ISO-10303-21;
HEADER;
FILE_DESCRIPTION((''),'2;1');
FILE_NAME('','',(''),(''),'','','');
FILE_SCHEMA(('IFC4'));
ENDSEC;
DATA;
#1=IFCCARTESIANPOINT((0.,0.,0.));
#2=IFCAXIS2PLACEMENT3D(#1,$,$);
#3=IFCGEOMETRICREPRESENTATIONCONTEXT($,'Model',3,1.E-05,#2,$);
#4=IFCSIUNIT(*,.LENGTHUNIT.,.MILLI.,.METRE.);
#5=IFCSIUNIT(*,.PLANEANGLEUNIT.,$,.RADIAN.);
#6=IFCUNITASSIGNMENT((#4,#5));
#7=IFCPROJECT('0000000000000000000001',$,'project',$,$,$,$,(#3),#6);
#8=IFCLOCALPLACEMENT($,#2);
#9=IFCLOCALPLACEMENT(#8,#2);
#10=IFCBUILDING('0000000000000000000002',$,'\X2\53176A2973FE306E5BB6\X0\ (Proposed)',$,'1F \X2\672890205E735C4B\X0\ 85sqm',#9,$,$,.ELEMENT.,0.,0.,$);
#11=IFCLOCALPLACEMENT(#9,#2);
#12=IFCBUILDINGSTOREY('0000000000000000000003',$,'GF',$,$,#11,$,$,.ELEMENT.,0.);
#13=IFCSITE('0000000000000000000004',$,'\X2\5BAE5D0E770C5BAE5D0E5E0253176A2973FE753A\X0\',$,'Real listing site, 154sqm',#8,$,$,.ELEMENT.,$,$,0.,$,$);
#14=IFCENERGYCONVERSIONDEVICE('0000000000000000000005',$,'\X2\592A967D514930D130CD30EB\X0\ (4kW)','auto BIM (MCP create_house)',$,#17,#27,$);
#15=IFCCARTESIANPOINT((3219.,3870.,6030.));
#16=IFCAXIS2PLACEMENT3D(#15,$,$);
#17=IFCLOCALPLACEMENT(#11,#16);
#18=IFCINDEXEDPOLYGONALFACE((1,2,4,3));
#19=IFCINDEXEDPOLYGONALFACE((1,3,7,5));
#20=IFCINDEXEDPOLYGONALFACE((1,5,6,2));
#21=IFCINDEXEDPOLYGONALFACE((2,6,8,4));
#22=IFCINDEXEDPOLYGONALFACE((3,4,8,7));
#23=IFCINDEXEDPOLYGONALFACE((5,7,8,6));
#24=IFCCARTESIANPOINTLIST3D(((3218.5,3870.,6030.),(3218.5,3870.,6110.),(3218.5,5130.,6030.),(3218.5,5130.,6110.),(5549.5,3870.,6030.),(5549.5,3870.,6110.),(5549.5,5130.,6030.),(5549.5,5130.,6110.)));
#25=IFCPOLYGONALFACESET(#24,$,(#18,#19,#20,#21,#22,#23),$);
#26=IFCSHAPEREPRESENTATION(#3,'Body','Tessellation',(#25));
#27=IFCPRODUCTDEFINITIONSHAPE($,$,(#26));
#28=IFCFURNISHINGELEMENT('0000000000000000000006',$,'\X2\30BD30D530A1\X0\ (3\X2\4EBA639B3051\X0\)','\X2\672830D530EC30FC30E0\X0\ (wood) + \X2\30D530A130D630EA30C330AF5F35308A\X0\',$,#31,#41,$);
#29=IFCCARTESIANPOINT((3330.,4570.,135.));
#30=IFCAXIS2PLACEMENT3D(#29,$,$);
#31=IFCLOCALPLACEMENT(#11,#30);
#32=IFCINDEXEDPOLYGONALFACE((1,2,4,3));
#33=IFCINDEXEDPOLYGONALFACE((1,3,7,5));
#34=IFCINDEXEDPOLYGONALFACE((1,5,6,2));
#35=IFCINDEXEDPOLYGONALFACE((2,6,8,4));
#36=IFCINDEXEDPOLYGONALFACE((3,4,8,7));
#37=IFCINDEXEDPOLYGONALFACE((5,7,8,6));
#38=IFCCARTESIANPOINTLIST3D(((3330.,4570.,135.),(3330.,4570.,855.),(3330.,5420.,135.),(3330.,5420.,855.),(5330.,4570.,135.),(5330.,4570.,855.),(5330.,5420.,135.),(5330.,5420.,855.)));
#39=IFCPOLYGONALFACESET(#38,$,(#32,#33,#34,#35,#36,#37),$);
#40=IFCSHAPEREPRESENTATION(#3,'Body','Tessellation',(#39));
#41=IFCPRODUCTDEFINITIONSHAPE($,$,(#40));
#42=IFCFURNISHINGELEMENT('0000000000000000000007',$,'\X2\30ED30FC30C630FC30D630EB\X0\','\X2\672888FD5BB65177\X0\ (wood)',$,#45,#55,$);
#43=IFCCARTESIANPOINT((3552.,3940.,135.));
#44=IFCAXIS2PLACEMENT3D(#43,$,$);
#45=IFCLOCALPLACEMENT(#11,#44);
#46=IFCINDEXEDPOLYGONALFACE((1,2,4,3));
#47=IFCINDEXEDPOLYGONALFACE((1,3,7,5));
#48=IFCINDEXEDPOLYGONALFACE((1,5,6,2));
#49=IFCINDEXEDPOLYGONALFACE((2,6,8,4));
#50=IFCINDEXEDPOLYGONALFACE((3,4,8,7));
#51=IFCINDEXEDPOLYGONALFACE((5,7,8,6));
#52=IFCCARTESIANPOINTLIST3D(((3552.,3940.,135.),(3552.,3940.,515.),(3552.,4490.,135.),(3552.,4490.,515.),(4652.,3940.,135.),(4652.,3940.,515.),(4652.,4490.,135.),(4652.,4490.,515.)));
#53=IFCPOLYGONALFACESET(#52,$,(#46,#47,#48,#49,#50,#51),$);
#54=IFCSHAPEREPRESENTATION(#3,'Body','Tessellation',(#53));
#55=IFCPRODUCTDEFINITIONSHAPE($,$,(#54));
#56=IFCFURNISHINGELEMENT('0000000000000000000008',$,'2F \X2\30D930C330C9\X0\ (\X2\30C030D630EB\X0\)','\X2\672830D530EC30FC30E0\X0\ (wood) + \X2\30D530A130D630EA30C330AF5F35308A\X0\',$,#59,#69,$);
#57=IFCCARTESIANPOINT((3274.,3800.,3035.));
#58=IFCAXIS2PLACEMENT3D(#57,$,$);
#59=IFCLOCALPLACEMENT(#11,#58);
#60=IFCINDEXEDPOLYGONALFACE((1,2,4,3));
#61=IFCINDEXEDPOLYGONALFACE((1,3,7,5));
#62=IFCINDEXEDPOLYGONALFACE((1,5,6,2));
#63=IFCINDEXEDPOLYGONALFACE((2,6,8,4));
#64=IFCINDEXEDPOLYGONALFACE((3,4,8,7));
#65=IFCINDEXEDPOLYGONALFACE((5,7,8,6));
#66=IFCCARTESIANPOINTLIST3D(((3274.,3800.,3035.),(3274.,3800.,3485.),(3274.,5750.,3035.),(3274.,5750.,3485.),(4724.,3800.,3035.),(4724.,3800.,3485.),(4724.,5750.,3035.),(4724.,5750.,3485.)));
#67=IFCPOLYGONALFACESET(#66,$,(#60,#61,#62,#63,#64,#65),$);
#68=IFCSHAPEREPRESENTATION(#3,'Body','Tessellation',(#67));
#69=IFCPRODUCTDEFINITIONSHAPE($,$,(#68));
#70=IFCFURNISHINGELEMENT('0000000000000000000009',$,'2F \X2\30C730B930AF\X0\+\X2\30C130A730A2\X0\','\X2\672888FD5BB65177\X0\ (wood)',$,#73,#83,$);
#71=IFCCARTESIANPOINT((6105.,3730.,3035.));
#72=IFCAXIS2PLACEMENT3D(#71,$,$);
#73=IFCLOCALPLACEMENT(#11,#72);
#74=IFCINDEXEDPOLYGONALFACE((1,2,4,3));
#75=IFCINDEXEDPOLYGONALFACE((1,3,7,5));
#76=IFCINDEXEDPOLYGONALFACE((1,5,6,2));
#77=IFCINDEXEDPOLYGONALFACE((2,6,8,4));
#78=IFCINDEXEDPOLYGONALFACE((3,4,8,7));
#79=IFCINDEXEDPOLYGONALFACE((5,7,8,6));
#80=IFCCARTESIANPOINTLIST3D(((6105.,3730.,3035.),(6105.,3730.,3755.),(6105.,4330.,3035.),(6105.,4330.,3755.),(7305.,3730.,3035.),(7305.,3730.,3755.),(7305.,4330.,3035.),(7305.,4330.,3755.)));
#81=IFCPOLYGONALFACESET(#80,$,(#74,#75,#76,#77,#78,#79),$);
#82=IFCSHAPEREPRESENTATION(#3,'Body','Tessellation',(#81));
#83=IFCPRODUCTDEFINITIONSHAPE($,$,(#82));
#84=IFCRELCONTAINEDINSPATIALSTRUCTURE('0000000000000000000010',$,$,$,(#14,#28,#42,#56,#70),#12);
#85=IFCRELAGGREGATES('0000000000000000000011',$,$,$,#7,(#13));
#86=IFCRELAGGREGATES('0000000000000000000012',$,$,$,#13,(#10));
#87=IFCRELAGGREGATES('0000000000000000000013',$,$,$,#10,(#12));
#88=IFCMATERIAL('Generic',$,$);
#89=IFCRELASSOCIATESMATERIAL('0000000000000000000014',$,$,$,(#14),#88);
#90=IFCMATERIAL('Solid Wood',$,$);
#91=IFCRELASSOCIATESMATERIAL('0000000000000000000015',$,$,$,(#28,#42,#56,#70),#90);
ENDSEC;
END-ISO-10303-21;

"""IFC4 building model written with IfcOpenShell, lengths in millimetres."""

from ifc_helpers import new_model, si_unit, frame, frame_2d, origin, place, context, project, spatial, rectangle, extrude, material, element, save


model = new_model("IFC4")

# Units and contexts
model_context = context("Model", 3, precision=1e-05, world=origin())
ifc_project = project(units=[si_unit("LENGTHUNIT", "METRE", prefix="MILLI"), si_unit("PLANEANGLEUNIT", "RADIAN")], contexts=[model_context])

# Site, building, storey
site_placement = place(None, origin())
site = spatial("IfcSite", under=ifc_project, at=site_placement, Name="宮崎県宮崎市北権現町", ObjectType="Real listing site, 154sqm", CompositionType="ELEMENT", RefElevation=0.0)
building_placement = place(site_placement, origin())
building = spatial("IfcBuilding", under=site, at=building_placement, Name="北権現の家 (Proposed)", ObjectType="1F 木造平屋 85sqm", CompositionType="ELEMENT", ElevationOfRefHeight=0.0, ElevationOfTerrain=0.0)
storey_placement = place(building_placement, origin())
storey = spatial("IfcBuildingStorey", under=building, at=storey_placement, Name="GF", CompositionType="ELEMENT", Elevation=0.0)

# Shared definitions
ifc_material_1 = material(Name="Solid Wood")

# Shared definitions
ifc_material_2 = material(Name="Generic")

# Energy conversion device
energy_conversion_device_placement = place(storey_placement, frame((3219.0, 3870.0, 6030.0)))
element("IfcEnergyConversionDevice", 1, at=energy_conversion_device_placement, inside=storey, material=ifc_material_2, Name="太陽光パネル (4kW)", Description="auto BIM (MCP create_house)", context=model_context, shape_type="SweptSolid", body=[
    extrude(rectangle(XDim=2331.0, YDim=1260.0, at=frame_2d((1165.0, 630.0))), frame((3219.0, 3870.0, 6030.0)), (0.0, 0.0, 1.0), 80.0),
])

# Furnishing elements
furnishing_1_placement = place(storey_placement, frame((3330.0, 4570.0, 135.0)))
element("IfcFurnishingElement", 2, at=furnishing_1_placement, inside=storey, material=ifc_material_1, Name="ソファ (3人掛け)", Description="木フレーム (wood) + ファブリック張り", context=model_context, shape_type="SweptSolid", body=[
    extrude(rectangle(XDim=2000.0, YDim=850.0, at=frame_2d((1000.0, 425.0))), frame((3330.0, 4570.0, 135.0)), (0.0, 0.0, 1.0), 720.0),
])
furnishing_2_placement = place(storey_placement, frame((3552.0, 3940.0, 135.0)))
element("IfcFurnishingElement", 3, at=furnishing_2_placement, inside=storey, material=ifc_material_1, Name="ローテーブル", Description="木製家具 (wood)", context=model_context, shape_type="SweptSolid", body=[
    extrude(rectangle(XDim=1100.0, YDim=550.0, at=frame_2d((550.0, 275.0))), frame((3552.0, 3940.0, 135.0)), (0.0, 0.0, 1.0), 380.0),
])
furnishing_3_placement = place(storey_placement, frame((3274.0, 3800.0, 3035.0)))
element("IfcFurnishingElement", 4, at=furnishing_3_placement, inside=storey, material=ifc_material_1, Name="2F ベッド (ダブル)", Description="木フレーム (wood) + ファブリック張り", context=model_context, shape_type="SweptSolid", body=[
    extrude(rectangle(XDim=1450.0, YDim=1950.0, at=frame_2d((725.0, 975.0))), frame((3274.0, 3800.0, 3035.0)), (0.0, 0.0, 1.0), 450.0),
])
furnishing_4_placement = place(storey_placement, frame((6105.0, 3730.0, 3035.0)))
element("IfcFurnishingElement", 5, at=furnishing_4_placement, inside=storey, material=ifc_material_1, Name="2F デスク+チェア", Description="木製家具 (wood)", context=model_context, shape_type="SweptSolid", body=[
    extrude(rectangle(XDim=1200.0, YDim=600.0, at=frame_2d((600.0, 300.0))), frame((6105.0, 3730.0, 3035.0)), (0.0, 0.0, 1.0), 720.0),
])

save(model, "model.ifc")
